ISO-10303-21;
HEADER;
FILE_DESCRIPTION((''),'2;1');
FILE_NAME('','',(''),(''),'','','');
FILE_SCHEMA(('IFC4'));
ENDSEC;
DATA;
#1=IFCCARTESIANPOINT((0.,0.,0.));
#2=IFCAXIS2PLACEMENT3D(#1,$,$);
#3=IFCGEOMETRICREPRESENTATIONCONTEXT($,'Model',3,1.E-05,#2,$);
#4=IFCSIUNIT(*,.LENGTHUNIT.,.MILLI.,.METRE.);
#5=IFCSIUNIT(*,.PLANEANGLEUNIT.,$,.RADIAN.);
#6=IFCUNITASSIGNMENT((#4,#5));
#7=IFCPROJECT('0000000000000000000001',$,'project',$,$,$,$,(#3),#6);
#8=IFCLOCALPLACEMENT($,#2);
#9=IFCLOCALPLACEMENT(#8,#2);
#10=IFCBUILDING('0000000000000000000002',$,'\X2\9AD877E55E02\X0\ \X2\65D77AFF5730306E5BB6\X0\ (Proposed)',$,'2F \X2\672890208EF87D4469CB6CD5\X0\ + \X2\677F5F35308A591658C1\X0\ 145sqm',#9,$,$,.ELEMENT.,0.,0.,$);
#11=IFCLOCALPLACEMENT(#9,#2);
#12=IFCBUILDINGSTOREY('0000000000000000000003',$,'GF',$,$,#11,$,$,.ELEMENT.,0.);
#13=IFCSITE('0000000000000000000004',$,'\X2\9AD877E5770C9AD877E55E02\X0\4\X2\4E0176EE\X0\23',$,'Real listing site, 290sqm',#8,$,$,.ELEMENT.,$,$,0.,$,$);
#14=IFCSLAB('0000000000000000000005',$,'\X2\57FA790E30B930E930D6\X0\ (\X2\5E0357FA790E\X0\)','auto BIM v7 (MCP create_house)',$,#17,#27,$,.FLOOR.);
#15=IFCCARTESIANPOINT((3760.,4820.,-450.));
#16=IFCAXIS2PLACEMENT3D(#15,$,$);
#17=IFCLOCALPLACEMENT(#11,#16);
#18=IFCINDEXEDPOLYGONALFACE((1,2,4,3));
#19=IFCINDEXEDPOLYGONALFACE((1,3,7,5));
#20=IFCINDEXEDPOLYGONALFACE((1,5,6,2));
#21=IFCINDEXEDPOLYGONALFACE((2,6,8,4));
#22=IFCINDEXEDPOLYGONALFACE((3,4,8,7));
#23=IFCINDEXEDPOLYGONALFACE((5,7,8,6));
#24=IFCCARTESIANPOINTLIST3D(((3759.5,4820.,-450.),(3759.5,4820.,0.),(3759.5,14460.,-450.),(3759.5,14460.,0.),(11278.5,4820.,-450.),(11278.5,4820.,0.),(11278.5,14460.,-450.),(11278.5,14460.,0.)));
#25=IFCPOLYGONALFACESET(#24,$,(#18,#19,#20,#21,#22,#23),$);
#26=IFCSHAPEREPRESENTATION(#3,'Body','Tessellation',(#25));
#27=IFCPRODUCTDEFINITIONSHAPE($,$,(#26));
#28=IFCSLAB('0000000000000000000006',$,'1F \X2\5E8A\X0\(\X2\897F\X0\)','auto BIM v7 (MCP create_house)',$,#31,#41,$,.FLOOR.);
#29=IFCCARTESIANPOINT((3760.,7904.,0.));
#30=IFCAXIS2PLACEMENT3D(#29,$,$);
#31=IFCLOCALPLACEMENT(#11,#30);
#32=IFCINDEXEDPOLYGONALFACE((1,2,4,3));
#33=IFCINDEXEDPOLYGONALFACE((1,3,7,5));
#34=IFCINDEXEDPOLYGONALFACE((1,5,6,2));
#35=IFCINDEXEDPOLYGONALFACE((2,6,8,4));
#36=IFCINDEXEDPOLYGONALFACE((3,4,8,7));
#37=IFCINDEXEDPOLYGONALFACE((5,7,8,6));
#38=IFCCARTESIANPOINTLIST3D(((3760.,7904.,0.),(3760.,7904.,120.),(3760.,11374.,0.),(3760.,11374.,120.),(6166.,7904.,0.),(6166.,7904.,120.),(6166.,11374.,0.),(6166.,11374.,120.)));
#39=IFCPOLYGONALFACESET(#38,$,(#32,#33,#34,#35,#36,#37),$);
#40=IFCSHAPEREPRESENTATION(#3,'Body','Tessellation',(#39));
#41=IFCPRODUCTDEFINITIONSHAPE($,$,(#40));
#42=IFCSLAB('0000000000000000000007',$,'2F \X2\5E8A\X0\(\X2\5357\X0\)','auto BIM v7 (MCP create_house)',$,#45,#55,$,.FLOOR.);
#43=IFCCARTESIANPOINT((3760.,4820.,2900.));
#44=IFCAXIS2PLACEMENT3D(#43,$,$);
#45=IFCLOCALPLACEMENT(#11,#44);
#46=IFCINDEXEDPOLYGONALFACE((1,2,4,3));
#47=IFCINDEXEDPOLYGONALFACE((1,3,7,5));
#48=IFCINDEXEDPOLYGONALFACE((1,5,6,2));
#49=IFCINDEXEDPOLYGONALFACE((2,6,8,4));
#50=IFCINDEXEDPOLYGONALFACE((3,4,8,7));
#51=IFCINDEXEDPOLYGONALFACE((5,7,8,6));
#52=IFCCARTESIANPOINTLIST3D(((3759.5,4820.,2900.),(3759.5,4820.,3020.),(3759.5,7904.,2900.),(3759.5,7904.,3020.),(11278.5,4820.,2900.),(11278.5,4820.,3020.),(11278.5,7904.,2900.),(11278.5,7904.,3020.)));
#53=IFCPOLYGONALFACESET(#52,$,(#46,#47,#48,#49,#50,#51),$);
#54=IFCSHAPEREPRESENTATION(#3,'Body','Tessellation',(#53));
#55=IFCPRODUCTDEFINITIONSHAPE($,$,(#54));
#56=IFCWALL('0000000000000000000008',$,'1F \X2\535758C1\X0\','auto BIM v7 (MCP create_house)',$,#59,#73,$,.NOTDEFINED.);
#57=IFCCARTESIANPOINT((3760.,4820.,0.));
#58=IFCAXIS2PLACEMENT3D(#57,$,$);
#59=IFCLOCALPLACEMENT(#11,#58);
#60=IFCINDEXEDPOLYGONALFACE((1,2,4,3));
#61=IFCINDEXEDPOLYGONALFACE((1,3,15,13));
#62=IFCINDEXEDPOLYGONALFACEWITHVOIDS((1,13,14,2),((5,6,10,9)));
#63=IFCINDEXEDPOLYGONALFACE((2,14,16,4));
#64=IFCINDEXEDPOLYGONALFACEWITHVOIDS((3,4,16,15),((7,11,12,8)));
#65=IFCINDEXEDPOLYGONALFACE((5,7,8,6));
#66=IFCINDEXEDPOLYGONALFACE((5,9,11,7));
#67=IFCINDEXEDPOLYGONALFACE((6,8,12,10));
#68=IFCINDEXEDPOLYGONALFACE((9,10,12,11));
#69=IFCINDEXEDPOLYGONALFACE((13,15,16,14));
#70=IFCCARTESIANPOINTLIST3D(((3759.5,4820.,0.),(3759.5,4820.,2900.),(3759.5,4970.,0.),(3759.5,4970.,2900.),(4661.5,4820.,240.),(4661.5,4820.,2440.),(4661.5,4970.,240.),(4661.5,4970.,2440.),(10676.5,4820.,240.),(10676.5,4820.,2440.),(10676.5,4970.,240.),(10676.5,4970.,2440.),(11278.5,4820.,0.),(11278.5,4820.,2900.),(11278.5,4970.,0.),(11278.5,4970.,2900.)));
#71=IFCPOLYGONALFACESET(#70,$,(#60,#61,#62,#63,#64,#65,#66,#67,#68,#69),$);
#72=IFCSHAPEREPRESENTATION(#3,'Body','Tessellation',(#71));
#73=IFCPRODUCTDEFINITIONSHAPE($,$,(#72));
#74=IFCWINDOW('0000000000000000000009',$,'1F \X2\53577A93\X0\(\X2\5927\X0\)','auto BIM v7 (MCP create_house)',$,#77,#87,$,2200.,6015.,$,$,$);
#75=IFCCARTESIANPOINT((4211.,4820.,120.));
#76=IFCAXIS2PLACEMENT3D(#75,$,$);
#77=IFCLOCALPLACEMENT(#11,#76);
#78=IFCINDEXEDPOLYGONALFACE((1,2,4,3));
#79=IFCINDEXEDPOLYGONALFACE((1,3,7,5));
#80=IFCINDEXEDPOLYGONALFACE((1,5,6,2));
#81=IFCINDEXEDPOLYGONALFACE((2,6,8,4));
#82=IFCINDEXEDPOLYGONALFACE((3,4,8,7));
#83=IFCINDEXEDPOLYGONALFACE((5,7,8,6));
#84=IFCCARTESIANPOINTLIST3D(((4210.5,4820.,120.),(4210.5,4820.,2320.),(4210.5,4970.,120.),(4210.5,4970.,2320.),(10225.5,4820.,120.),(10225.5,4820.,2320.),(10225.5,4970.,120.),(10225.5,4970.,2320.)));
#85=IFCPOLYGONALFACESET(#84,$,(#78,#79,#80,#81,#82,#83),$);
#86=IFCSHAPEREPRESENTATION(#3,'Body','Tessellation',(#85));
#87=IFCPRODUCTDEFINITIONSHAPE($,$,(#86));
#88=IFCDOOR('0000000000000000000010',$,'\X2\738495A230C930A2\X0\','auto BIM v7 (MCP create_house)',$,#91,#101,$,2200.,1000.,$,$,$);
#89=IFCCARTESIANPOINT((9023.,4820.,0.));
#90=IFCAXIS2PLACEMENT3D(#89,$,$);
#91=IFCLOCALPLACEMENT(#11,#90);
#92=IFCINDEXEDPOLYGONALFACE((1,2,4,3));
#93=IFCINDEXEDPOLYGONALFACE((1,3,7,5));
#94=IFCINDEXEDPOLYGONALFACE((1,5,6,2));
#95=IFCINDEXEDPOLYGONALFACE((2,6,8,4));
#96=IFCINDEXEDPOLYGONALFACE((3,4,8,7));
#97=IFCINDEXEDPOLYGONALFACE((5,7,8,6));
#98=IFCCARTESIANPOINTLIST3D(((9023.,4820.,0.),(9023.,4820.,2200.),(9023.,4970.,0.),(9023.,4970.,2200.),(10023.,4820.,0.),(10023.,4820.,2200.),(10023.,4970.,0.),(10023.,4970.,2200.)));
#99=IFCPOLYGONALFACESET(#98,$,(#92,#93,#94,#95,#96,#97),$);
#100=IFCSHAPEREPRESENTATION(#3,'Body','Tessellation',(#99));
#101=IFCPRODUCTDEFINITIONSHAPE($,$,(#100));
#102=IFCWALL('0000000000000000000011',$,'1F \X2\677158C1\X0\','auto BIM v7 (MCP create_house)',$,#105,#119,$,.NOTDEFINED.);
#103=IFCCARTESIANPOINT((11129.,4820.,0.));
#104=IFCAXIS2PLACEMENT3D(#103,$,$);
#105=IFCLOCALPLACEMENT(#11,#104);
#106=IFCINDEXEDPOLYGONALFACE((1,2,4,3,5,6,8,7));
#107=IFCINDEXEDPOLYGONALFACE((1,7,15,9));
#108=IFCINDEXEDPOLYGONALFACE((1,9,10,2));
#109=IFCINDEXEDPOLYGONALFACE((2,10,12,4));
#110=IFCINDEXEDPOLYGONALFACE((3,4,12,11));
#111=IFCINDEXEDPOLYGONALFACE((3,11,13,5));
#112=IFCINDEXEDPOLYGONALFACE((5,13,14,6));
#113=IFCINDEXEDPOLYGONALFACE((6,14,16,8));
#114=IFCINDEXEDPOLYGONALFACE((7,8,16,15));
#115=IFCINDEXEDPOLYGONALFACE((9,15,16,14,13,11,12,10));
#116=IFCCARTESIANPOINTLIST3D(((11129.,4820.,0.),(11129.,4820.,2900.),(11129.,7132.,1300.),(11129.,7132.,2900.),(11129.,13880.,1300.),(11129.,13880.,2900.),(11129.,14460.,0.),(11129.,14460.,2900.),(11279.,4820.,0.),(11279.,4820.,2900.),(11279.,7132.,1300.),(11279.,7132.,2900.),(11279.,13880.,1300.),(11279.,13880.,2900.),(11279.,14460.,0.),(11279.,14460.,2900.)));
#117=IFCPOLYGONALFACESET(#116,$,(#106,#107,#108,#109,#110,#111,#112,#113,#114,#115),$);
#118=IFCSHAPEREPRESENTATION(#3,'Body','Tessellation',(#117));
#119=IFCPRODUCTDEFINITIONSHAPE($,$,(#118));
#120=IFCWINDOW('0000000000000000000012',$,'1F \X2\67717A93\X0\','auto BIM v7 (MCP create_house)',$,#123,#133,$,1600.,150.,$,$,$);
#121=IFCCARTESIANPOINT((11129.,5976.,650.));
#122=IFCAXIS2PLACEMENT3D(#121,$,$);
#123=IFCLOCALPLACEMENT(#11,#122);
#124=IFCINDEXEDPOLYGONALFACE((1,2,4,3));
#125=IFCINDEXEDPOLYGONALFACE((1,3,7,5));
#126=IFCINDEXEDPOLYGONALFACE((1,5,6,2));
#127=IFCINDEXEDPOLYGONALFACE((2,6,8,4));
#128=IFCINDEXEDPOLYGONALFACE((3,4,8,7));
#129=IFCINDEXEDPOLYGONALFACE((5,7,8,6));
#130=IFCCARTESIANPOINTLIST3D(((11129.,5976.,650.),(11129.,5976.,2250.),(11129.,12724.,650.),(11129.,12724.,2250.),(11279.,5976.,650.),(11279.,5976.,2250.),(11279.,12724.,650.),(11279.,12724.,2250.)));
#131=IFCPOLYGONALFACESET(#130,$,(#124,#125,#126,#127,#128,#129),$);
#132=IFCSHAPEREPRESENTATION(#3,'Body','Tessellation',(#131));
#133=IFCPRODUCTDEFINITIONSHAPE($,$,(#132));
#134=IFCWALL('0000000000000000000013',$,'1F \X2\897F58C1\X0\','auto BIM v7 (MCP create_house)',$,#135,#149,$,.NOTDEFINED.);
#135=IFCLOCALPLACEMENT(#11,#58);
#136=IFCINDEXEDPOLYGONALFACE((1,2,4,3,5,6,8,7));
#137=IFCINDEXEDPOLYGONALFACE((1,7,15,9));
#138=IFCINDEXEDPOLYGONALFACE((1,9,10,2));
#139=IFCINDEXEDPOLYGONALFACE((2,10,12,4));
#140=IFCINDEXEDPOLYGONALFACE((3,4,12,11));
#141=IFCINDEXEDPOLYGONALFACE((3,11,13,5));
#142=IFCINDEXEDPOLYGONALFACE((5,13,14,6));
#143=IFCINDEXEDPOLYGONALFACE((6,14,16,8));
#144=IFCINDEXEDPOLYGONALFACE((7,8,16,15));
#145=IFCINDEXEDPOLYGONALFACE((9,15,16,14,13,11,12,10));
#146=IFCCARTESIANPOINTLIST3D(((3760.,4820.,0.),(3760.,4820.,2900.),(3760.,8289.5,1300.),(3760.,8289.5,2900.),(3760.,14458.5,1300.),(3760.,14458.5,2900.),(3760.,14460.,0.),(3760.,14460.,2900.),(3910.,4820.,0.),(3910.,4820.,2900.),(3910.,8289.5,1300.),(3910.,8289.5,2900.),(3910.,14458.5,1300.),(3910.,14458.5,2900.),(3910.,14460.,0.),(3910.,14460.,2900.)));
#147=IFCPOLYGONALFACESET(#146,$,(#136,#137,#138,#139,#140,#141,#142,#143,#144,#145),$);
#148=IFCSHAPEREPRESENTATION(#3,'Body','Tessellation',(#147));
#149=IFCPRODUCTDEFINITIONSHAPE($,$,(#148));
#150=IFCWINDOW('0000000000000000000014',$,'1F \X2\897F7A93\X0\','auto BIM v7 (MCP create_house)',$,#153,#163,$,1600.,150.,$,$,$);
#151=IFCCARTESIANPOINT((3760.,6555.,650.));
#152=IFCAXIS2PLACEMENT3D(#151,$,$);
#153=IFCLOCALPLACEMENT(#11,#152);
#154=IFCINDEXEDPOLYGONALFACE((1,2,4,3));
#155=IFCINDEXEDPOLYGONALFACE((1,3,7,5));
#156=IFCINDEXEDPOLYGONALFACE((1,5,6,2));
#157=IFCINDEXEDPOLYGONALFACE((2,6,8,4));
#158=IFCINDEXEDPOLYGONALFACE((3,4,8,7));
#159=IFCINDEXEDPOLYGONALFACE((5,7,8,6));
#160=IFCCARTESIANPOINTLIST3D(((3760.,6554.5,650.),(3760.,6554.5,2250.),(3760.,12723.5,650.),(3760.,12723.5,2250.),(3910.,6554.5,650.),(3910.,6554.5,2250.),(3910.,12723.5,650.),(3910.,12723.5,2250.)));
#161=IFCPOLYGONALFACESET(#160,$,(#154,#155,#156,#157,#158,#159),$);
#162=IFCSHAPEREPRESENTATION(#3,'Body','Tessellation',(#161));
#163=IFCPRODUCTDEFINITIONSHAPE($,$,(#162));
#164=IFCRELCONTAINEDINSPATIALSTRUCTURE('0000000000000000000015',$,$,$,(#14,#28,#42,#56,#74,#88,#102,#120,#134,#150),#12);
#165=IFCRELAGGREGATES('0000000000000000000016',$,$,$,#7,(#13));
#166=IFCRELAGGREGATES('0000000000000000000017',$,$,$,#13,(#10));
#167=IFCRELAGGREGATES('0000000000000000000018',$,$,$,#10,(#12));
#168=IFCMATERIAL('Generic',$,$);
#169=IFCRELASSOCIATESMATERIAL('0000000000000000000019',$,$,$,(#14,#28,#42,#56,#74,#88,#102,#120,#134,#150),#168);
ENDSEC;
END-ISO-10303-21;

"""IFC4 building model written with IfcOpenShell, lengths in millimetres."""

from ifc_helpers import new_model, si_unit, frame, frame_2d, origin, place, context, project, spatial, rectangle, extrude, material, element, fill, save


model = new_model("IFC4")

# Units and contexts
model_context = context("Model", 3, precision=1e-05, world=origin())
ifc_project = project(units=[si_unit("LENGTHUNIT", "METRE", prefix="MILLI"), si_unit("PLANEANGLEUNIT", "RADIAN")], contexts=[model_context])

# Site, building, storey
site_placement = place(None, origin())
site = spatial("IfcSite", under=ifc_project, at=site_placement, Name="高知県高知市4丁目23", ObjectType="Real listing site, 290sqm", CompositionType="ELEMENT", RefElevation=0.0)
building_placement = place(site_placement, origin())
building = spatial("IfcBuilding", under=site, at=building_placement, Name="高知市 旗竿地の家 (Proposed)", ObjectType="2F 木造軸組構法 + 板張り外壁 145sqm", CompositionType="ELEMENT", ElevationOfRefHeight=0.0, ElevationOfTerrain=0.0)
storey_placement = place(building_placement, origin())
storey = spatial("IfcBuildingStorey", under=building, at=storey_placement, Name="GF", CompositionType="ELEMENT", Elevation=0.0)

# Slabs
ifc_material = material(Name="Generic")
slab_1_placement = place(storey_placement, frame((3760.0, 4820.0, -450.0)))
element("IfcSlab", 1, at=slab_1_placement, inside=storey, material=ifc_material, Name="基礎スラブ (布基礎)", Description="auto BIM v7 (MCP create_house)", PredefinedType="FLOOR", context=model_context, shape_type="SweptSolid", body=[
    extrude(rectangle(XDim=7519.0, YDim=9640.0, at=frame_2d((3759.0, 4820.0))), frame((3760.0, 4820.0, -450.0)), (0.0, 0.0, 1.0), 450.0),
])
slab_2_placement = place(storey_placement, frame((3760.0, 7904.0, 0.0)))
element("IfcSlab", 2, at=slab_2_placement, inside=storey, material=ifc_material, Name="1F 床(西)", Description="auto BIM v7 (MCP create_house)", PredefinedType="FLOOR", context=model_context, shape_type="SweptSolid", body=[
    extrude(rectangle(XDim=2406.0, YDim=3470.0, at=frame_2d((1203.0, 1735.0))), frame((3760.0, 7904.0, 0.0)), (0.0, 0.0, 1.0), 120.0),
])
slab_3_placement = place(storey_placement, frame((3760.0, 4820.0, 2900.0)))
element("IfcSlab", 3, at=slab_3_placement, inside=storey, material=ifc_material, Name="2F 床(南)", Description="auto BIM v7 (MCP create_house)", PredefinedType="FLOOR", context=model_context, shape_type="SweptSolid", body=[
    extrude(rectangle(XDim=7519.0, YDim=3084.0, at=frame_2d((3759.0, 1542.0))), frame((3760.0, 4820.0, 2900.0)), (0.0, 0.0, 1.0), 120.0),
])

# Wall, openings, window, door
wall_1_placement = place(storey_placement, frame((3760.0, 4820.0, 0.0)))
wall_1 = element("IfcWall", 4, at=wall_1_placement, inside=storey, material=ifc_material, Name="1F 南壁", Description="auto BIM v7 (MCP create_house)", PredefinedType="NOTDEFINED", context=model_context, shape_type="SweptSolid", body=[
    extrude(rectangle(XDim=7519.0, YDim=150.0, at=frame_2d((3759.0, 75.0))), frame((3760.0, 4820.0, 0.0)), (0.0, 0.0, 1.0), 2900.0),
])
opening_1_placement = place(storey_placement, frame((4211.0, 4820.0, 120.0)))
opening_1 = element("IfcOpeningElement", 5, at=opening_1_placement, cuts=wall_1, PredefinedType="NOTDEFINED", context=model_context, shape_type="SweptSolid", body=[
    extrude(rectangle(XDim=6015.0, YDim=150.0, at=frame_2d((3007.0, 75.0))), frame((4211.0, 4820.0, 120.0)), (0.0, 0.0, 1.0), 2200.0),
])
opening_2_placement = place(storey_placement, frame((9023.0, 4820.0, 0.0)))
opening_2 = element("IfcOpeningElement", 6, at=opening_2_placement, cuts=wall_1, PredefinedType="NOTDEFINED", context=model_context, shape_type="SweptSolid", body=[
    extrude(rectangle(XDim=1000.0, YDim=150.0, at=frame_2d((500.0, 75.0))), frame((9023.0, 4820.0, 0.0)), (0.0, 0.0, 1.0), 2200.0),
])
window_1_placement = place(storey_placement, frame((4211.0, 4820.0, 120.0)))
window_1 = element("IfcWindow", 7, at=window_1_placement, inside=storey, material=ifc_material, Name="1F 南窓(大)", Description="auto BIM v7 (MCP create_house)", OverallHeight=2200.0, OverallWidth=6015.0, context=model_context, shape_type="SweptSolid", body=[
    extrude(rectangle(XDim=6015.0, YDim=150.0, at=frame_2d((3007.0, 75.0))), frame((4211.0, 4820.0, 120.0)), (0.0, 0.0, 1.0), 2200.0),
])
fill(opening_1, window_1)
door_placement = place(storey_placement, frame((9023.0, 4820.0, 0.0)))
door = element("IfcDoor", 8, at=door_placement, inside=storey, material=ifc_material, Name="玄関ドア", Description="auto BIM v7 (MCP create_house)", OverallHeight=2200.0, OverallWidth=1000.0, context=model_context, shape_type="SweptSolid", body=[
    extrude(rectangle(XDim=1000.0, YDim=150.0, at=frame_2d((500.0, 75.0))), frame((9023.0, 4820.0, 0.0)), (0.0, 0.0, 1.0), 2200.0),
])
fill(opening_2, door)

# Walls, openings, windows
wall_2_placement = place(storey_placement, frame((11129.0, 4820.0, 0.0)))
wall_2 = element("IfcWall", 9, at=wall_2_placement, inside=storey, material=ifc_material, Name="1F 東壁", Description="auto BIM v7 (MCP create_house)", PredefinedType="NOTDEFINED", context=model_context, shape_type="SweptSolid", body=[
    extrude(rectangle(XDim=150.0, YDim=9640.0, at=frame_2d((75.0, 4820.0))), frame((11129.0, 4820.0, 0.0)), (0.0, 0.0, 1.0), 2900.0),
])
opening_3_placement = place(storey_placement, frame((11129.0, 5976.0, 650.0)))
opening_3 = element("IfcOpeningElement", 10, at=opening_3_placement, cuts=wall_2, PredefinedType="NOTDEFINED", context=model_context, shape_type="SweptSolid", body=[
    extrude(rectangle(XDim=150.0, YDim=6748.0, at=frame_2d((75.0, 3374.0))), frame((11129.0, 5976.0, 650.0)), (0.0, 0.0, 1.0), 1600.0),
])
window_2_placement = place(storey_placement, frame((11129.0, 5976.0, 650.0)))
window_2 = element("IfcWindow", 11, at=window_2_placement, inside=storey, material=ifc_material, Name="1F 東窓", Description="auto BIM v7 (MCP create_house)", OverallHeight=1600.0, OverallWidth=150.0, context=model_context, shape_type="SweptSolid", body=[
    extrude(rectangle(XDim=150.0, YDim=6748.0, at=frame_2d((75.0, 3374.0))), frame((11129.0, 5976.0, 650.0)), (0.0, 0.0, 1.0), 1600.0),
])
fill(opening_3, window_2)
wall_3_placement = place(storey_placement, frame((3760.0, 4820.0, 0.0)))
wall_3 = element("IfcWall", 12, at=wall_3_placement, inside=storey, material=ifc_material, Name="1F 西壁", Description="auto BIM v7 (MCP create_house)", PredefinedType="NOTDEFINED", context=model_context, shape_type="SweptSolid", body=[
    extrude(rectangle(XDim=150.0, YDim=9640.0, at=frame_2d((75.0, 4820.0))), frame((3760.0, 4820.0, 0.0)), (0.0, 0.0, 1.0), 2900.0),
])
opening_4_placement = place(storey_placement, frame((3760.0, 6555.0, 650.0)))
opening_4 = element("IfcOpeningElement", 13, at=opening_4_placement, cuts=wall_3, PredefinedType="NOTDEFINED", context=model_context, shape_type="SweptSolid", body=[
    extrude(rectangle(XDim=150.0, YDim=6169.0, at=frame_2d((75.0, 3084.0))), frame((3760.0, 6555.0, 650.0)), (0.0, 0.0, 1.0), 1600.0),
])
window_3_placement = place(storey_placement, frame((3760.0, 6555.0, 650.0)))
window_3 = element("IfcWindow", 14, at=window_3_placement, inside=storey, material=ifc_material, Name="1F 西窓", Description="auto BIM v7 (MCP create_house)", OverallHeight=1600.0, OverallWidth=150.0, context=model_context, shape_type="SweptSolid", body=[
    extrude(rectangle(XDim=150.0, YDim=6169.0, at=frame_2d((75.0, 3084.0))), frame((3760.0, 6555.0, 650.0)), (0.0, 0.0, 1.0), 1600.0),
])
fill(opening_4, window_3)

save(model, "model.ifc")
